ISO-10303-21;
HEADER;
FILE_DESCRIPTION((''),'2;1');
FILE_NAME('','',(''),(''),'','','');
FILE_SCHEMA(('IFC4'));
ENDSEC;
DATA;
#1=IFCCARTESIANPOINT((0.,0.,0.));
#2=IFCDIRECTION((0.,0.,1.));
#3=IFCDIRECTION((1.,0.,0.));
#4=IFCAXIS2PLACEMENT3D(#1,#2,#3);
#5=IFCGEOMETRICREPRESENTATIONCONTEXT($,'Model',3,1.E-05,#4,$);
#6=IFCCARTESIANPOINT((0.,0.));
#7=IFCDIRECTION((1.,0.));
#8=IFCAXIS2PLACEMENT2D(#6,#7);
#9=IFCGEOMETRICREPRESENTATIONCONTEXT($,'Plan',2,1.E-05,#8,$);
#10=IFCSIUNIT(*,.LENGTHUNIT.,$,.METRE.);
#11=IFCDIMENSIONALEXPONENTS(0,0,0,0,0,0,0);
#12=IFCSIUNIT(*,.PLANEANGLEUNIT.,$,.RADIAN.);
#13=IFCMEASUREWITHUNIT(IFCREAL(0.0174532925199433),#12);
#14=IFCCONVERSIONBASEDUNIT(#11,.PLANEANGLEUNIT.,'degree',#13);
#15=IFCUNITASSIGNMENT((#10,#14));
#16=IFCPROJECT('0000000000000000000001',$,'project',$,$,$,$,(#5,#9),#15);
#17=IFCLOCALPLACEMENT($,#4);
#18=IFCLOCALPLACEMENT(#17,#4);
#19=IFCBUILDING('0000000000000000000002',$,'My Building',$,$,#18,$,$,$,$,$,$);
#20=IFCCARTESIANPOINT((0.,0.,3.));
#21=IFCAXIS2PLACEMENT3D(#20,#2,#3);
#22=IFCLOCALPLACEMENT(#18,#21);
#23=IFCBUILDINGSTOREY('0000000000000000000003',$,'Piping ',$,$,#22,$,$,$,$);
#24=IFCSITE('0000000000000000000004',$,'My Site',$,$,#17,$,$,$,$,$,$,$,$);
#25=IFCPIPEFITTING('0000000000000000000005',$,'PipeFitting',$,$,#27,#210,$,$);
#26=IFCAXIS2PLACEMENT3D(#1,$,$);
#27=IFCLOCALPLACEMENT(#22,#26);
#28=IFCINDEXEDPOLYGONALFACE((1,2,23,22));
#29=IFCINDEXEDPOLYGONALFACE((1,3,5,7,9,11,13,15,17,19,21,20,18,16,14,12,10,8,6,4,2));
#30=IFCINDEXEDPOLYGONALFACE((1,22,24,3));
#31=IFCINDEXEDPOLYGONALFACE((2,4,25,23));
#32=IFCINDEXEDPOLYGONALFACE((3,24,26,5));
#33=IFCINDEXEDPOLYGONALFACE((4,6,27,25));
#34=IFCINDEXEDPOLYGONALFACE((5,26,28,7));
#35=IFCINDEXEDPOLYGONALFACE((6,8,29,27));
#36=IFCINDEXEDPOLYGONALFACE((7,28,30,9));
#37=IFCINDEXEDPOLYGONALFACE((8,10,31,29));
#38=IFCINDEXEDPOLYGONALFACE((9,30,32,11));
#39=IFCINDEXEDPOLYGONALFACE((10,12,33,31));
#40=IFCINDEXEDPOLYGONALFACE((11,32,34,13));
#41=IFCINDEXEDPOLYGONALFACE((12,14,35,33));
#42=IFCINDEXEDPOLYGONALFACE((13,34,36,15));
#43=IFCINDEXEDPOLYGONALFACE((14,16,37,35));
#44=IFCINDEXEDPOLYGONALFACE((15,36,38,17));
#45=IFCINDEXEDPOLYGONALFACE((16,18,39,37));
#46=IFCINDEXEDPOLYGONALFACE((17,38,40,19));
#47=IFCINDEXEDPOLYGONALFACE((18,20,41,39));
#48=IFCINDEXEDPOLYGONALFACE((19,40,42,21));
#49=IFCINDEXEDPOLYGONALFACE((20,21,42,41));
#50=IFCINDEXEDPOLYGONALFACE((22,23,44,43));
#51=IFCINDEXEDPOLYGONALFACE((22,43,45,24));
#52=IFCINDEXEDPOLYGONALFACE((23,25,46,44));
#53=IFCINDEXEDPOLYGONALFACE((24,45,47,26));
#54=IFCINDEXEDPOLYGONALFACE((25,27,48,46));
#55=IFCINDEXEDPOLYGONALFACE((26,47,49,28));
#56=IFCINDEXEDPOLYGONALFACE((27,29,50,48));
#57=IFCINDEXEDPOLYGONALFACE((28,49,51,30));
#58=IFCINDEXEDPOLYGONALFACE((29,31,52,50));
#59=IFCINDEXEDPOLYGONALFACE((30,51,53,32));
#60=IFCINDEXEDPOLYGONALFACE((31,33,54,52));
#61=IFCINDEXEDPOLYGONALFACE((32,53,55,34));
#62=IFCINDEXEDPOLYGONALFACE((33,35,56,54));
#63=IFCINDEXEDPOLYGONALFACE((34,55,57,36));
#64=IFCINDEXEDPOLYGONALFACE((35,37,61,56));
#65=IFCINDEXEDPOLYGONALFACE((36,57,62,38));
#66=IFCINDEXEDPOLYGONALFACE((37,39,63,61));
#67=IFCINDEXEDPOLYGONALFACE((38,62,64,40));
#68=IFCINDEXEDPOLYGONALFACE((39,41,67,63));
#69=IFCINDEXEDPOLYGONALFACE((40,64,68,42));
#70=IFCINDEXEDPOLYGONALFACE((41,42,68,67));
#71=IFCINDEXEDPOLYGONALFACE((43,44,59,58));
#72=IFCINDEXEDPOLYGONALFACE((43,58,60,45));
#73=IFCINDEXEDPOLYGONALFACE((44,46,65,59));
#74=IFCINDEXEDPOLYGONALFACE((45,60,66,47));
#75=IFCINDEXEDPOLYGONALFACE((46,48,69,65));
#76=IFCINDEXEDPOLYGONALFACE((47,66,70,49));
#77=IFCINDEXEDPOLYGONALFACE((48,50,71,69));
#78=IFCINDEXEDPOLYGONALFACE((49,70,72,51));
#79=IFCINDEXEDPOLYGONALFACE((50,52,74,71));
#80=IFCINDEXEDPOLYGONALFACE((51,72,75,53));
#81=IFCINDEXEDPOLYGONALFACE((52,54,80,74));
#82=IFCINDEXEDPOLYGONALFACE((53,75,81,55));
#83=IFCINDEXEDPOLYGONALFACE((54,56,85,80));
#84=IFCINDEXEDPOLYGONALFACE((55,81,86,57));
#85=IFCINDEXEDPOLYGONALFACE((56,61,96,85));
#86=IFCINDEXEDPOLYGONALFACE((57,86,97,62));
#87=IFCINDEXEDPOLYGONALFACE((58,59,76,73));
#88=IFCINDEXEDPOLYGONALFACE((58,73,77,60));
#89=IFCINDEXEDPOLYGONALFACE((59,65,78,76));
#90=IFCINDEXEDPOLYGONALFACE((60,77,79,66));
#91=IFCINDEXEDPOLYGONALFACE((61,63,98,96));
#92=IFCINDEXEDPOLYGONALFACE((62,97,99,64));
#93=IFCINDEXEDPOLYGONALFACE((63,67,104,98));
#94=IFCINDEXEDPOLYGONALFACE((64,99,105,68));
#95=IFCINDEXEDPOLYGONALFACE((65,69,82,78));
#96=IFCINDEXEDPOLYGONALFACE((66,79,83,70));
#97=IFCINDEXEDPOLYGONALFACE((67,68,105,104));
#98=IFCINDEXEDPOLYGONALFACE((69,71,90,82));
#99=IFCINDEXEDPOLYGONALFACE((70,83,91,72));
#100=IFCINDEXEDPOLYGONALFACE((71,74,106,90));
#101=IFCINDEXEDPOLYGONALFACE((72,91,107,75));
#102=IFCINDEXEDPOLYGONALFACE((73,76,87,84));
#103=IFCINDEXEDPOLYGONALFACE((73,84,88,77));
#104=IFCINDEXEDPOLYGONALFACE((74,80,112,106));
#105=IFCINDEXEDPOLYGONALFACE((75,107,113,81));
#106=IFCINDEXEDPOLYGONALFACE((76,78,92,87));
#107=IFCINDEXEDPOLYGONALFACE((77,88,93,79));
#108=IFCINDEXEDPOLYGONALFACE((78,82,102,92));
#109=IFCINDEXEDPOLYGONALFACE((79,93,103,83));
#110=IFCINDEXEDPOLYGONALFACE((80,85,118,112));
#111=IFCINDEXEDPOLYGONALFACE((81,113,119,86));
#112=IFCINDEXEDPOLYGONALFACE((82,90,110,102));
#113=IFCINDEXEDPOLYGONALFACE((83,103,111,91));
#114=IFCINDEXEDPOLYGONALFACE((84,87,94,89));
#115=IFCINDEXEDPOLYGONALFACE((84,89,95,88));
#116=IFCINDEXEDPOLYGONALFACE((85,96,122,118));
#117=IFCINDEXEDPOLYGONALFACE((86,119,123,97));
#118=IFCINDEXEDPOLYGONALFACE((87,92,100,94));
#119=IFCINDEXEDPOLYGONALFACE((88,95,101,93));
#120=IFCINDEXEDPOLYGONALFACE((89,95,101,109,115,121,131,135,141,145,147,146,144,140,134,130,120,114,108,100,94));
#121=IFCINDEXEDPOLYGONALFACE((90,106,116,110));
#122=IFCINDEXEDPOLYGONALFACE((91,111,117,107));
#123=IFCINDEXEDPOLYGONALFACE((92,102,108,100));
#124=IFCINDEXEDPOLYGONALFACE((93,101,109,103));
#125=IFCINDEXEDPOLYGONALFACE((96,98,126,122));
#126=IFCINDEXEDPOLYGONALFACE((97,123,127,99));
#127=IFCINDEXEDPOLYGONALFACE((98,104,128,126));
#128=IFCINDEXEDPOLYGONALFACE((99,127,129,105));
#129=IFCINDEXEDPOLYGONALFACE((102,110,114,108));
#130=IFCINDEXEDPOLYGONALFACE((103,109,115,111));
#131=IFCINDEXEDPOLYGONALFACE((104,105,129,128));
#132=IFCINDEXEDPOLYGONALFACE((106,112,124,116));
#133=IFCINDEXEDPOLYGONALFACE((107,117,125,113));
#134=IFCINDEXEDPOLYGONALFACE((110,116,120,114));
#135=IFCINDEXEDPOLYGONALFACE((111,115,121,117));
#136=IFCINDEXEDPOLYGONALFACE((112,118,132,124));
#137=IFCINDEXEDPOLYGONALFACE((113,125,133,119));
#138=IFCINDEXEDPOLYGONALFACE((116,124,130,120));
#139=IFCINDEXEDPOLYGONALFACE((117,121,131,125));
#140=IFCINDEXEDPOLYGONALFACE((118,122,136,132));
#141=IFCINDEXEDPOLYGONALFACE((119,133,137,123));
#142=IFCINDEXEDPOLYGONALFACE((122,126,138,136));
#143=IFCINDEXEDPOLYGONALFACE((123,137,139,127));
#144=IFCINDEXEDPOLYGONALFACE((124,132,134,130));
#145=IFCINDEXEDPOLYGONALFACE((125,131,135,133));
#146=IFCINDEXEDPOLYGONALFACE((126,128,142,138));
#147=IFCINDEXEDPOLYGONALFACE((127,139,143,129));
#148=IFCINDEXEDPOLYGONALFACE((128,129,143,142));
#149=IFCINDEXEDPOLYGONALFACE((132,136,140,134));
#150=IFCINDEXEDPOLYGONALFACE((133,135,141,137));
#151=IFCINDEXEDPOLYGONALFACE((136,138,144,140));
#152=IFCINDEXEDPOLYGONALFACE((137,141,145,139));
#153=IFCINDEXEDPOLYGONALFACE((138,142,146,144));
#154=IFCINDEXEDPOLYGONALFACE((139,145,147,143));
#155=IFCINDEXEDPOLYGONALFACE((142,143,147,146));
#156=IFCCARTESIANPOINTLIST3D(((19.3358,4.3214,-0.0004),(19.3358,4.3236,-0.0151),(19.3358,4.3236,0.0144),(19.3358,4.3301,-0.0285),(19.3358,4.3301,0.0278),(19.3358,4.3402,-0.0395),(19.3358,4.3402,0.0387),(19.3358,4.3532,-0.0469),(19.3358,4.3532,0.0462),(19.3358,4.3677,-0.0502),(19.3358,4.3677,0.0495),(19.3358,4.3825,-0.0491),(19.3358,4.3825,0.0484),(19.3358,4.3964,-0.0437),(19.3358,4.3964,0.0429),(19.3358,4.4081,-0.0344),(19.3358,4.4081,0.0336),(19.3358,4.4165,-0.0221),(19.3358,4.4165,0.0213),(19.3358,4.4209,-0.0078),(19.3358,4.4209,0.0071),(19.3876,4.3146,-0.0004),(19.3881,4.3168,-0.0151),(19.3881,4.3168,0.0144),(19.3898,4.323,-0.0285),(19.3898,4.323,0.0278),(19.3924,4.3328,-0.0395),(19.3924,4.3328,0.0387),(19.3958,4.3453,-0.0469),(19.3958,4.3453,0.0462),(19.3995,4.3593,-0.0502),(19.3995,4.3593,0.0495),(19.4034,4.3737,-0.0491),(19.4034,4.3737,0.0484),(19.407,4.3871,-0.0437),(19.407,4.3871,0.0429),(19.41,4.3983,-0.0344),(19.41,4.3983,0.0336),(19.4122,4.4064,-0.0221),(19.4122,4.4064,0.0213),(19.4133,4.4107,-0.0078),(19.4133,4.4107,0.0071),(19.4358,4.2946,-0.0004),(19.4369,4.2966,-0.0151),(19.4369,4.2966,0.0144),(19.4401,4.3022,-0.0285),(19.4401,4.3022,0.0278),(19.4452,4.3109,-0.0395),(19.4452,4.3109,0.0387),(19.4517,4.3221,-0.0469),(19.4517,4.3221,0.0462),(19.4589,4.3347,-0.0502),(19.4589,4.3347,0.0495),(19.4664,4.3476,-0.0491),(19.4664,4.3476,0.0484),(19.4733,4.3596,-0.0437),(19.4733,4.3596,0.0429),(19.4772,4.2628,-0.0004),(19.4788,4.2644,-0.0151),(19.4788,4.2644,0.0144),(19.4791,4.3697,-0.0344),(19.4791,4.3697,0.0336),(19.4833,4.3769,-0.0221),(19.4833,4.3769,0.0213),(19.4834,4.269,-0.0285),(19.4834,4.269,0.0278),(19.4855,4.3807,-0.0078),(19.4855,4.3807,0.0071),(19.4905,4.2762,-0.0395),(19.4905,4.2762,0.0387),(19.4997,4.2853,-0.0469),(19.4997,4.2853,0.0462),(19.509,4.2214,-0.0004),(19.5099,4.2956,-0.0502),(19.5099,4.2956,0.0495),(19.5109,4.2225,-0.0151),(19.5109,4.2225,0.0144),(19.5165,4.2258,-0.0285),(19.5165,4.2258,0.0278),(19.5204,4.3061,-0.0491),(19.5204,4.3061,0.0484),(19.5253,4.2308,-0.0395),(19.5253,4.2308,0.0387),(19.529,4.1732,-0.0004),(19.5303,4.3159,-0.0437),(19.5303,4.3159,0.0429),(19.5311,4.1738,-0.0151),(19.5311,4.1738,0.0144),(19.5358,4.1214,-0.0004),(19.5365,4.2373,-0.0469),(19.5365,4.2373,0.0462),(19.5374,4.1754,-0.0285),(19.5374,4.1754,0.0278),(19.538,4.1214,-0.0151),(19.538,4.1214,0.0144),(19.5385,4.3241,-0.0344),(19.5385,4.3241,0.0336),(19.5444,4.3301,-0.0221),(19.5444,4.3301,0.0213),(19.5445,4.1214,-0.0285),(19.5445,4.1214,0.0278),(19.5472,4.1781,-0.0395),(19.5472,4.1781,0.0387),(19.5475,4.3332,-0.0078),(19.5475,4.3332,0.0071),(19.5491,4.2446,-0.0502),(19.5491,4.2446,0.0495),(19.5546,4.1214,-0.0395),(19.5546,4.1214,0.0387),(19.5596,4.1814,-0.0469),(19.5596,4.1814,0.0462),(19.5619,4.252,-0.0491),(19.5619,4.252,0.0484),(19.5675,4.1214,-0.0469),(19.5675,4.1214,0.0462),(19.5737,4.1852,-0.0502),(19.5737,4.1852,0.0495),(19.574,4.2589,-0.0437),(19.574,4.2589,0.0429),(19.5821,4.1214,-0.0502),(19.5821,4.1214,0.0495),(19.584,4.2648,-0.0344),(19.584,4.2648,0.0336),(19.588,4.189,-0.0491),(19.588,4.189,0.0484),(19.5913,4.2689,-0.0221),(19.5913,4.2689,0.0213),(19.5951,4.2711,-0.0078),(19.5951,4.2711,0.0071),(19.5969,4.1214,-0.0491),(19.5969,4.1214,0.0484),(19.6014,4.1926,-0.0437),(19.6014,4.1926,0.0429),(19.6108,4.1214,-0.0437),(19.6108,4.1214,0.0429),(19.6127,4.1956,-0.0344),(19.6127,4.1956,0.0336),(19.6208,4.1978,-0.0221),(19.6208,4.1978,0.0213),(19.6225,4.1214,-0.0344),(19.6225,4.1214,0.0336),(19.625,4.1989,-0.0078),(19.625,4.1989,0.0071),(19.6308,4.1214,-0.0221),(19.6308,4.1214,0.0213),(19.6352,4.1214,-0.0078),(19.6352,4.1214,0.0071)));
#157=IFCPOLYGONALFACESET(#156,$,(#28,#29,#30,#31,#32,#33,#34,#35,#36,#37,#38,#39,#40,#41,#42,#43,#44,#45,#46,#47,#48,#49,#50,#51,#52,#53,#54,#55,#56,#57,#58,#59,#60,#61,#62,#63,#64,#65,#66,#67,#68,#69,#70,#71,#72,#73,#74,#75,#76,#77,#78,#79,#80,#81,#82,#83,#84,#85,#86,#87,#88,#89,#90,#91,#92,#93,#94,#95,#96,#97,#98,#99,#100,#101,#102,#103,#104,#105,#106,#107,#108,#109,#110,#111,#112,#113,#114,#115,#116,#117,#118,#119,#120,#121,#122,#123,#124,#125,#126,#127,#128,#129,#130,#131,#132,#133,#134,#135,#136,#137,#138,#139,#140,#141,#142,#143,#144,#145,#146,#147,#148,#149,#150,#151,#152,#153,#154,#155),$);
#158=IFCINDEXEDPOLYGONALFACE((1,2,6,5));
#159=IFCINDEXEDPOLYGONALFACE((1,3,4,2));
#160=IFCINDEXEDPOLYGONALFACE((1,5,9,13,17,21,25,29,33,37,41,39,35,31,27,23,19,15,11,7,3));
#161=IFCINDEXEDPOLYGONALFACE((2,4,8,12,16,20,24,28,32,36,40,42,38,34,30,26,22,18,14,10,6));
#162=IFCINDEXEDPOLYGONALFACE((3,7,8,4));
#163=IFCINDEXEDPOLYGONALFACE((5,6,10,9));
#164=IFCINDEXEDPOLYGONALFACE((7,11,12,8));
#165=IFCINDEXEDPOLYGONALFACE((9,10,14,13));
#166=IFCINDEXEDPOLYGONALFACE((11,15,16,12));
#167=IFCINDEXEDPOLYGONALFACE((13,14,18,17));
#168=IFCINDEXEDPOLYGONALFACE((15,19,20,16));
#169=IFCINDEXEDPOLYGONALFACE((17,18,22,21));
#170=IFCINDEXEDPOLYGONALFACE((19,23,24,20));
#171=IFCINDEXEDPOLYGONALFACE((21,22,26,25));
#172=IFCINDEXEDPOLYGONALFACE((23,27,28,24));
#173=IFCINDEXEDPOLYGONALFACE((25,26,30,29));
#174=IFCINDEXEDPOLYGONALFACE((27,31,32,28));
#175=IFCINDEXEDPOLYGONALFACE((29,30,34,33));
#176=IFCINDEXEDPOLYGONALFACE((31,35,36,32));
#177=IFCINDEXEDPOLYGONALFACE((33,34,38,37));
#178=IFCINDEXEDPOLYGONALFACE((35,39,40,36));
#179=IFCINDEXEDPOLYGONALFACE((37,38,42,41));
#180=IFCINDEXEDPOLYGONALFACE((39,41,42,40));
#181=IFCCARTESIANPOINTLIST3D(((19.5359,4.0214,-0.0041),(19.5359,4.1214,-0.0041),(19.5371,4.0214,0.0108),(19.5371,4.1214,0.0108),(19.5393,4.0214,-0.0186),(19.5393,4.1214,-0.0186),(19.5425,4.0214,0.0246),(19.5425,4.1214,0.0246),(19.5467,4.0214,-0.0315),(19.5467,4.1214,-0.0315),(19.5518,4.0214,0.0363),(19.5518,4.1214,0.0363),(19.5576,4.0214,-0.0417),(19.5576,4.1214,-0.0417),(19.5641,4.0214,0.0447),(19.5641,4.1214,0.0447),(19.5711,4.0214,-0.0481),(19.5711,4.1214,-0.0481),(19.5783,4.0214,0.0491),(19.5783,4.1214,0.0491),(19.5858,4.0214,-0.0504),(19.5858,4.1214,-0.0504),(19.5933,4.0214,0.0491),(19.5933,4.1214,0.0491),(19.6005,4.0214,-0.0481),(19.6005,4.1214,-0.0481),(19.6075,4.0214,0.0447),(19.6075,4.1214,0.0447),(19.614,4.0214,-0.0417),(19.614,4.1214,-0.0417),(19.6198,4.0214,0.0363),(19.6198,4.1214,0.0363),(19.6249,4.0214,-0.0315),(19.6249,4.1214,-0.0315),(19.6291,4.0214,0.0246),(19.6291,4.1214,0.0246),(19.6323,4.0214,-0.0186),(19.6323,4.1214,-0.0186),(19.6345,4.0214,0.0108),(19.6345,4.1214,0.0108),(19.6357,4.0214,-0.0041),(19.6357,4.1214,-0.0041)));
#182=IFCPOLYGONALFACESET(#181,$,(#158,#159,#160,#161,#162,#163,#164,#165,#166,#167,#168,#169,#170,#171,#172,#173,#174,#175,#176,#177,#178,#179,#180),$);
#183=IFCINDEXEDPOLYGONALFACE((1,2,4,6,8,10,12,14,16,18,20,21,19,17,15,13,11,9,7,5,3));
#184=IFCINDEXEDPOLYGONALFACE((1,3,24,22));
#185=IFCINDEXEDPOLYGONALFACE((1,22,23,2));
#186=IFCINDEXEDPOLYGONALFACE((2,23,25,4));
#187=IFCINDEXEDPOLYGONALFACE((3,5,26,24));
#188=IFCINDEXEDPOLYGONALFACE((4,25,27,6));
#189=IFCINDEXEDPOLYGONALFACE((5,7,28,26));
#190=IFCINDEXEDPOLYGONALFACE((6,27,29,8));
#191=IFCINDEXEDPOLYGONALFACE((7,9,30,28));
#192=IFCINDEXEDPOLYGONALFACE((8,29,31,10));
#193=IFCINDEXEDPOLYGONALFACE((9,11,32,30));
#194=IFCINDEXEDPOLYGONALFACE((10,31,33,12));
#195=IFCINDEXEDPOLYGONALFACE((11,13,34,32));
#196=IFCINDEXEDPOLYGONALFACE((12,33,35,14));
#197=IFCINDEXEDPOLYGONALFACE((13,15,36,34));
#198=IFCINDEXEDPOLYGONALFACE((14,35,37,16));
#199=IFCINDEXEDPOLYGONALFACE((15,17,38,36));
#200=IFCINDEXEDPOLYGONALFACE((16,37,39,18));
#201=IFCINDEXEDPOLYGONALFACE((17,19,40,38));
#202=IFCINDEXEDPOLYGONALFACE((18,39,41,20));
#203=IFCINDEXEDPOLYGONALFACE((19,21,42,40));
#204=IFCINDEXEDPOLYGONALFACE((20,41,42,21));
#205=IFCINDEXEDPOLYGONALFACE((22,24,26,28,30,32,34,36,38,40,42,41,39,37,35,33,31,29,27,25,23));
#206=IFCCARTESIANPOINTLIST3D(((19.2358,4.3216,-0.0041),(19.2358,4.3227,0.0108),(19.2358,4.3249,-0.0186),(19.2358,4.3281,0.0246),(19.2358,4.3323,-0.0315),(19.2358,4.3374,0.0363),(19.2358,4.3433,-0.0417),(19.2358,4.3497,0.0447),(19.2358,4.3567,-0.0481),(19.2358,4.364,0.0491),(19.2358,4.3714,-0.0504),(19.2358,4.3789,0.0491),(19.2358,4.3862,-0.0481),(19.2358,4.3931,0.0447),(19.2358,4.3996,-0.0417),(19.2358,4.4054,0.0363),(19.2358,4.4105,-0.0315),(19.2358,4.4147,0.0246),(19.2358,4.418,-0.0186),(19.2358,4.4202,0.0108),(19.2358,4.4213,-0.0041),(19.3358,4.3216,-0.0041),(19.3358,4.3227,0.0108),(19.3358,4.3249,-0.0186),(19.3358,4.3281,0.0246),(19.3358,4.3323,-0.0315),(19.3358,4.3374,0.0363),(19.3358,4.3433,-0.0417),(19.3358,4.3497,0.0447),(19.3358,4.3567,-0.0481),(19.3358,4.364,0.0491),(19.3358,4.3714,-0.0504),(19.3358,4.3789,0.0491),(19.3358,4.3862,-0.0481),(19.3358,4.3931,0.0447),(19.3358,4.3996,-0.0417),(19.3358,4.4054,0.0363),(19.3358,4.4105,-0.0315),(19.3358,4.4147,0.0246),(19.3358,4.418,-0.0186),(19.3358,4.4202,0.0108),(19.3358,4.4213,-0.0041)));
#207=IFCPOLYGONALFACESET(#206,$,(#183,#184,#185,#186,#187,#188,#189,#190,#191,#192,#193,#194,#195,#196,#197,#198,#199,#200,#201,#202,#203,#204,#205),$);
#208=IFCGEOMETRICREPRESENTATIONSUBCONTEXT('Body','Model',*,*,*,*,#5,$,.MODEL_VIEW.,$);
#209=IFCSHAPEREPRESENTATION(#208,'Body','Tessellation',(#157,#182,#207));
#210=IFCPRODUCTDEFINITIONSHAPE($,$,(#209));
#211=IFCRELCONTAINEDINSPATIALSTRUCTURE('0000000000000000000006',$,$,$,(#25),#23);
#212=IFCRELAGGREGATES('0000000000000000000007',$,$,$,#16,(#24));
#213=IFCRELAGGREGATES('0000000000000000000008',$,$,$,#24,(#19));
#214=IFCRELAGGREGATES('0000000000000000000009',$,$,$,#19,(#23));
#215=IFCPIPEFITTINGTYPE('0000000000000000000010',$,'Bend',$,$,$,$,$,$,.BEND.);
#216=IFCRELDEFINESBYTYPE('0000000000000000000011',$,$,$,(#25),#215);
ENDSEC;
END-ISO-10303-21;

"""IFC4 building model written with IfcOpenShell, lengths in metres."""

from ifc_helpers import new_model, entity, si_unit, converted_unit, frame, origin_with_axes, origin_2d_with_axis, place, context, subcontext, project, spatial, circle, extrude, source, transform, mapped, type_object, type_shapes, element, save


model = new_model("IFC4")

# Units and contexts
model_context = context("Model", 3, precision=1e-05, world=origin_with_axes())
plan_context = context("Plan", 2, precision=1e-05, world=origin_2d_with_axis())
body_context = subcontext(model_context, "Body", "Model", "MODEL_VIEW")
ifc_project = project(units=[si_unit("LENGTHUNIT", "METRE"), converted_unit("PLANEANGLEUNIT", "degree", entity("IfcReal", 0.0174532925199433), si_unit("PLANEANGLEUNIT", "RADIAN"), dimensions=[0, 0, 0, 0, 0, 0, 0])], contexts=[model_context, plan_context])

# Site, building, storey
site_placement = place(None, origin_with_axes())
site = spatial("IfcSite", under=ifc_project, at=site_placement, Name="My Site")
building_placement = place(site_placement, origin_with_axes())
building = spatial("IfcBuilding", under=site, at=building_placement, Name="My Building")
storey_placement = place(building_placement, frame((0.0, 0.0, 3.0), z_axis=(0.0, 0.0, 1.0), x_axis=(1.0, 0.0, 0.0)))
storey = spatial("IfcBuildingStorey", under=building, at=storey_placement, Name="Piping ")

# Pipe fitting
pipe_fitting_type = type_object("IfcPipeFittingType", Name="Bend", PredefinedType="BEND")
shared_shape = source(origin_with_axes(), body_context, "Body", "SolidModel", [
    entity("IfcSweptDiskSolid", entity("IfcIndexedPolyCurve", entity("IfcCartesianPointList3D", [[0.0, 0.0, -0.1], [0.0, -0.0732, -0.2768], [0.0, -0.25, -0.35]]), [entity("IfcArcIndex", [1, 2, 3])]), 0.05),
    extrude(circle(Radius=0.05), origin_with_axes(), (0.0, 0.0, -1.0), 0.1),
    extrude(circle(Radius=0.05), frame((0.0, -0.25, -0.35), z_axis=(0.0, -1.0, 0.0), x_axis=(1.0, 0.0, 0.0)), (0.0, 0.0, 1.0), 0.1),
])
type_shapes(pipe_fitting_type, [shared_shape])
for number, where, z_axis, x_axis, name in (
    (1, (19.5858, 4.0214, -0.0004), (0.0, -1.0, 0.0), (0.0, 0.0, -1.0), "PipeFitting"),
):
    element("IfcPipeFitting", number, at=place(storey_placement, frame(where, z_axis=z_axis, x_axis=x_axis)), inside=storey, type_object=pipe_fitting_type, Name=name, context=body_context, shape_type="MappedRepresentation", body=[
        mapped(shared_shape, transform((0.0, 0.0, 0.0), x_axis=(1.0, 0.0, 0.0), y_axis=(0.0, 1.0, 0.0), z_axis=(0.0, 0.0, 1.0), scale=1.0)),
    ])

save(model, "model.ifc")
